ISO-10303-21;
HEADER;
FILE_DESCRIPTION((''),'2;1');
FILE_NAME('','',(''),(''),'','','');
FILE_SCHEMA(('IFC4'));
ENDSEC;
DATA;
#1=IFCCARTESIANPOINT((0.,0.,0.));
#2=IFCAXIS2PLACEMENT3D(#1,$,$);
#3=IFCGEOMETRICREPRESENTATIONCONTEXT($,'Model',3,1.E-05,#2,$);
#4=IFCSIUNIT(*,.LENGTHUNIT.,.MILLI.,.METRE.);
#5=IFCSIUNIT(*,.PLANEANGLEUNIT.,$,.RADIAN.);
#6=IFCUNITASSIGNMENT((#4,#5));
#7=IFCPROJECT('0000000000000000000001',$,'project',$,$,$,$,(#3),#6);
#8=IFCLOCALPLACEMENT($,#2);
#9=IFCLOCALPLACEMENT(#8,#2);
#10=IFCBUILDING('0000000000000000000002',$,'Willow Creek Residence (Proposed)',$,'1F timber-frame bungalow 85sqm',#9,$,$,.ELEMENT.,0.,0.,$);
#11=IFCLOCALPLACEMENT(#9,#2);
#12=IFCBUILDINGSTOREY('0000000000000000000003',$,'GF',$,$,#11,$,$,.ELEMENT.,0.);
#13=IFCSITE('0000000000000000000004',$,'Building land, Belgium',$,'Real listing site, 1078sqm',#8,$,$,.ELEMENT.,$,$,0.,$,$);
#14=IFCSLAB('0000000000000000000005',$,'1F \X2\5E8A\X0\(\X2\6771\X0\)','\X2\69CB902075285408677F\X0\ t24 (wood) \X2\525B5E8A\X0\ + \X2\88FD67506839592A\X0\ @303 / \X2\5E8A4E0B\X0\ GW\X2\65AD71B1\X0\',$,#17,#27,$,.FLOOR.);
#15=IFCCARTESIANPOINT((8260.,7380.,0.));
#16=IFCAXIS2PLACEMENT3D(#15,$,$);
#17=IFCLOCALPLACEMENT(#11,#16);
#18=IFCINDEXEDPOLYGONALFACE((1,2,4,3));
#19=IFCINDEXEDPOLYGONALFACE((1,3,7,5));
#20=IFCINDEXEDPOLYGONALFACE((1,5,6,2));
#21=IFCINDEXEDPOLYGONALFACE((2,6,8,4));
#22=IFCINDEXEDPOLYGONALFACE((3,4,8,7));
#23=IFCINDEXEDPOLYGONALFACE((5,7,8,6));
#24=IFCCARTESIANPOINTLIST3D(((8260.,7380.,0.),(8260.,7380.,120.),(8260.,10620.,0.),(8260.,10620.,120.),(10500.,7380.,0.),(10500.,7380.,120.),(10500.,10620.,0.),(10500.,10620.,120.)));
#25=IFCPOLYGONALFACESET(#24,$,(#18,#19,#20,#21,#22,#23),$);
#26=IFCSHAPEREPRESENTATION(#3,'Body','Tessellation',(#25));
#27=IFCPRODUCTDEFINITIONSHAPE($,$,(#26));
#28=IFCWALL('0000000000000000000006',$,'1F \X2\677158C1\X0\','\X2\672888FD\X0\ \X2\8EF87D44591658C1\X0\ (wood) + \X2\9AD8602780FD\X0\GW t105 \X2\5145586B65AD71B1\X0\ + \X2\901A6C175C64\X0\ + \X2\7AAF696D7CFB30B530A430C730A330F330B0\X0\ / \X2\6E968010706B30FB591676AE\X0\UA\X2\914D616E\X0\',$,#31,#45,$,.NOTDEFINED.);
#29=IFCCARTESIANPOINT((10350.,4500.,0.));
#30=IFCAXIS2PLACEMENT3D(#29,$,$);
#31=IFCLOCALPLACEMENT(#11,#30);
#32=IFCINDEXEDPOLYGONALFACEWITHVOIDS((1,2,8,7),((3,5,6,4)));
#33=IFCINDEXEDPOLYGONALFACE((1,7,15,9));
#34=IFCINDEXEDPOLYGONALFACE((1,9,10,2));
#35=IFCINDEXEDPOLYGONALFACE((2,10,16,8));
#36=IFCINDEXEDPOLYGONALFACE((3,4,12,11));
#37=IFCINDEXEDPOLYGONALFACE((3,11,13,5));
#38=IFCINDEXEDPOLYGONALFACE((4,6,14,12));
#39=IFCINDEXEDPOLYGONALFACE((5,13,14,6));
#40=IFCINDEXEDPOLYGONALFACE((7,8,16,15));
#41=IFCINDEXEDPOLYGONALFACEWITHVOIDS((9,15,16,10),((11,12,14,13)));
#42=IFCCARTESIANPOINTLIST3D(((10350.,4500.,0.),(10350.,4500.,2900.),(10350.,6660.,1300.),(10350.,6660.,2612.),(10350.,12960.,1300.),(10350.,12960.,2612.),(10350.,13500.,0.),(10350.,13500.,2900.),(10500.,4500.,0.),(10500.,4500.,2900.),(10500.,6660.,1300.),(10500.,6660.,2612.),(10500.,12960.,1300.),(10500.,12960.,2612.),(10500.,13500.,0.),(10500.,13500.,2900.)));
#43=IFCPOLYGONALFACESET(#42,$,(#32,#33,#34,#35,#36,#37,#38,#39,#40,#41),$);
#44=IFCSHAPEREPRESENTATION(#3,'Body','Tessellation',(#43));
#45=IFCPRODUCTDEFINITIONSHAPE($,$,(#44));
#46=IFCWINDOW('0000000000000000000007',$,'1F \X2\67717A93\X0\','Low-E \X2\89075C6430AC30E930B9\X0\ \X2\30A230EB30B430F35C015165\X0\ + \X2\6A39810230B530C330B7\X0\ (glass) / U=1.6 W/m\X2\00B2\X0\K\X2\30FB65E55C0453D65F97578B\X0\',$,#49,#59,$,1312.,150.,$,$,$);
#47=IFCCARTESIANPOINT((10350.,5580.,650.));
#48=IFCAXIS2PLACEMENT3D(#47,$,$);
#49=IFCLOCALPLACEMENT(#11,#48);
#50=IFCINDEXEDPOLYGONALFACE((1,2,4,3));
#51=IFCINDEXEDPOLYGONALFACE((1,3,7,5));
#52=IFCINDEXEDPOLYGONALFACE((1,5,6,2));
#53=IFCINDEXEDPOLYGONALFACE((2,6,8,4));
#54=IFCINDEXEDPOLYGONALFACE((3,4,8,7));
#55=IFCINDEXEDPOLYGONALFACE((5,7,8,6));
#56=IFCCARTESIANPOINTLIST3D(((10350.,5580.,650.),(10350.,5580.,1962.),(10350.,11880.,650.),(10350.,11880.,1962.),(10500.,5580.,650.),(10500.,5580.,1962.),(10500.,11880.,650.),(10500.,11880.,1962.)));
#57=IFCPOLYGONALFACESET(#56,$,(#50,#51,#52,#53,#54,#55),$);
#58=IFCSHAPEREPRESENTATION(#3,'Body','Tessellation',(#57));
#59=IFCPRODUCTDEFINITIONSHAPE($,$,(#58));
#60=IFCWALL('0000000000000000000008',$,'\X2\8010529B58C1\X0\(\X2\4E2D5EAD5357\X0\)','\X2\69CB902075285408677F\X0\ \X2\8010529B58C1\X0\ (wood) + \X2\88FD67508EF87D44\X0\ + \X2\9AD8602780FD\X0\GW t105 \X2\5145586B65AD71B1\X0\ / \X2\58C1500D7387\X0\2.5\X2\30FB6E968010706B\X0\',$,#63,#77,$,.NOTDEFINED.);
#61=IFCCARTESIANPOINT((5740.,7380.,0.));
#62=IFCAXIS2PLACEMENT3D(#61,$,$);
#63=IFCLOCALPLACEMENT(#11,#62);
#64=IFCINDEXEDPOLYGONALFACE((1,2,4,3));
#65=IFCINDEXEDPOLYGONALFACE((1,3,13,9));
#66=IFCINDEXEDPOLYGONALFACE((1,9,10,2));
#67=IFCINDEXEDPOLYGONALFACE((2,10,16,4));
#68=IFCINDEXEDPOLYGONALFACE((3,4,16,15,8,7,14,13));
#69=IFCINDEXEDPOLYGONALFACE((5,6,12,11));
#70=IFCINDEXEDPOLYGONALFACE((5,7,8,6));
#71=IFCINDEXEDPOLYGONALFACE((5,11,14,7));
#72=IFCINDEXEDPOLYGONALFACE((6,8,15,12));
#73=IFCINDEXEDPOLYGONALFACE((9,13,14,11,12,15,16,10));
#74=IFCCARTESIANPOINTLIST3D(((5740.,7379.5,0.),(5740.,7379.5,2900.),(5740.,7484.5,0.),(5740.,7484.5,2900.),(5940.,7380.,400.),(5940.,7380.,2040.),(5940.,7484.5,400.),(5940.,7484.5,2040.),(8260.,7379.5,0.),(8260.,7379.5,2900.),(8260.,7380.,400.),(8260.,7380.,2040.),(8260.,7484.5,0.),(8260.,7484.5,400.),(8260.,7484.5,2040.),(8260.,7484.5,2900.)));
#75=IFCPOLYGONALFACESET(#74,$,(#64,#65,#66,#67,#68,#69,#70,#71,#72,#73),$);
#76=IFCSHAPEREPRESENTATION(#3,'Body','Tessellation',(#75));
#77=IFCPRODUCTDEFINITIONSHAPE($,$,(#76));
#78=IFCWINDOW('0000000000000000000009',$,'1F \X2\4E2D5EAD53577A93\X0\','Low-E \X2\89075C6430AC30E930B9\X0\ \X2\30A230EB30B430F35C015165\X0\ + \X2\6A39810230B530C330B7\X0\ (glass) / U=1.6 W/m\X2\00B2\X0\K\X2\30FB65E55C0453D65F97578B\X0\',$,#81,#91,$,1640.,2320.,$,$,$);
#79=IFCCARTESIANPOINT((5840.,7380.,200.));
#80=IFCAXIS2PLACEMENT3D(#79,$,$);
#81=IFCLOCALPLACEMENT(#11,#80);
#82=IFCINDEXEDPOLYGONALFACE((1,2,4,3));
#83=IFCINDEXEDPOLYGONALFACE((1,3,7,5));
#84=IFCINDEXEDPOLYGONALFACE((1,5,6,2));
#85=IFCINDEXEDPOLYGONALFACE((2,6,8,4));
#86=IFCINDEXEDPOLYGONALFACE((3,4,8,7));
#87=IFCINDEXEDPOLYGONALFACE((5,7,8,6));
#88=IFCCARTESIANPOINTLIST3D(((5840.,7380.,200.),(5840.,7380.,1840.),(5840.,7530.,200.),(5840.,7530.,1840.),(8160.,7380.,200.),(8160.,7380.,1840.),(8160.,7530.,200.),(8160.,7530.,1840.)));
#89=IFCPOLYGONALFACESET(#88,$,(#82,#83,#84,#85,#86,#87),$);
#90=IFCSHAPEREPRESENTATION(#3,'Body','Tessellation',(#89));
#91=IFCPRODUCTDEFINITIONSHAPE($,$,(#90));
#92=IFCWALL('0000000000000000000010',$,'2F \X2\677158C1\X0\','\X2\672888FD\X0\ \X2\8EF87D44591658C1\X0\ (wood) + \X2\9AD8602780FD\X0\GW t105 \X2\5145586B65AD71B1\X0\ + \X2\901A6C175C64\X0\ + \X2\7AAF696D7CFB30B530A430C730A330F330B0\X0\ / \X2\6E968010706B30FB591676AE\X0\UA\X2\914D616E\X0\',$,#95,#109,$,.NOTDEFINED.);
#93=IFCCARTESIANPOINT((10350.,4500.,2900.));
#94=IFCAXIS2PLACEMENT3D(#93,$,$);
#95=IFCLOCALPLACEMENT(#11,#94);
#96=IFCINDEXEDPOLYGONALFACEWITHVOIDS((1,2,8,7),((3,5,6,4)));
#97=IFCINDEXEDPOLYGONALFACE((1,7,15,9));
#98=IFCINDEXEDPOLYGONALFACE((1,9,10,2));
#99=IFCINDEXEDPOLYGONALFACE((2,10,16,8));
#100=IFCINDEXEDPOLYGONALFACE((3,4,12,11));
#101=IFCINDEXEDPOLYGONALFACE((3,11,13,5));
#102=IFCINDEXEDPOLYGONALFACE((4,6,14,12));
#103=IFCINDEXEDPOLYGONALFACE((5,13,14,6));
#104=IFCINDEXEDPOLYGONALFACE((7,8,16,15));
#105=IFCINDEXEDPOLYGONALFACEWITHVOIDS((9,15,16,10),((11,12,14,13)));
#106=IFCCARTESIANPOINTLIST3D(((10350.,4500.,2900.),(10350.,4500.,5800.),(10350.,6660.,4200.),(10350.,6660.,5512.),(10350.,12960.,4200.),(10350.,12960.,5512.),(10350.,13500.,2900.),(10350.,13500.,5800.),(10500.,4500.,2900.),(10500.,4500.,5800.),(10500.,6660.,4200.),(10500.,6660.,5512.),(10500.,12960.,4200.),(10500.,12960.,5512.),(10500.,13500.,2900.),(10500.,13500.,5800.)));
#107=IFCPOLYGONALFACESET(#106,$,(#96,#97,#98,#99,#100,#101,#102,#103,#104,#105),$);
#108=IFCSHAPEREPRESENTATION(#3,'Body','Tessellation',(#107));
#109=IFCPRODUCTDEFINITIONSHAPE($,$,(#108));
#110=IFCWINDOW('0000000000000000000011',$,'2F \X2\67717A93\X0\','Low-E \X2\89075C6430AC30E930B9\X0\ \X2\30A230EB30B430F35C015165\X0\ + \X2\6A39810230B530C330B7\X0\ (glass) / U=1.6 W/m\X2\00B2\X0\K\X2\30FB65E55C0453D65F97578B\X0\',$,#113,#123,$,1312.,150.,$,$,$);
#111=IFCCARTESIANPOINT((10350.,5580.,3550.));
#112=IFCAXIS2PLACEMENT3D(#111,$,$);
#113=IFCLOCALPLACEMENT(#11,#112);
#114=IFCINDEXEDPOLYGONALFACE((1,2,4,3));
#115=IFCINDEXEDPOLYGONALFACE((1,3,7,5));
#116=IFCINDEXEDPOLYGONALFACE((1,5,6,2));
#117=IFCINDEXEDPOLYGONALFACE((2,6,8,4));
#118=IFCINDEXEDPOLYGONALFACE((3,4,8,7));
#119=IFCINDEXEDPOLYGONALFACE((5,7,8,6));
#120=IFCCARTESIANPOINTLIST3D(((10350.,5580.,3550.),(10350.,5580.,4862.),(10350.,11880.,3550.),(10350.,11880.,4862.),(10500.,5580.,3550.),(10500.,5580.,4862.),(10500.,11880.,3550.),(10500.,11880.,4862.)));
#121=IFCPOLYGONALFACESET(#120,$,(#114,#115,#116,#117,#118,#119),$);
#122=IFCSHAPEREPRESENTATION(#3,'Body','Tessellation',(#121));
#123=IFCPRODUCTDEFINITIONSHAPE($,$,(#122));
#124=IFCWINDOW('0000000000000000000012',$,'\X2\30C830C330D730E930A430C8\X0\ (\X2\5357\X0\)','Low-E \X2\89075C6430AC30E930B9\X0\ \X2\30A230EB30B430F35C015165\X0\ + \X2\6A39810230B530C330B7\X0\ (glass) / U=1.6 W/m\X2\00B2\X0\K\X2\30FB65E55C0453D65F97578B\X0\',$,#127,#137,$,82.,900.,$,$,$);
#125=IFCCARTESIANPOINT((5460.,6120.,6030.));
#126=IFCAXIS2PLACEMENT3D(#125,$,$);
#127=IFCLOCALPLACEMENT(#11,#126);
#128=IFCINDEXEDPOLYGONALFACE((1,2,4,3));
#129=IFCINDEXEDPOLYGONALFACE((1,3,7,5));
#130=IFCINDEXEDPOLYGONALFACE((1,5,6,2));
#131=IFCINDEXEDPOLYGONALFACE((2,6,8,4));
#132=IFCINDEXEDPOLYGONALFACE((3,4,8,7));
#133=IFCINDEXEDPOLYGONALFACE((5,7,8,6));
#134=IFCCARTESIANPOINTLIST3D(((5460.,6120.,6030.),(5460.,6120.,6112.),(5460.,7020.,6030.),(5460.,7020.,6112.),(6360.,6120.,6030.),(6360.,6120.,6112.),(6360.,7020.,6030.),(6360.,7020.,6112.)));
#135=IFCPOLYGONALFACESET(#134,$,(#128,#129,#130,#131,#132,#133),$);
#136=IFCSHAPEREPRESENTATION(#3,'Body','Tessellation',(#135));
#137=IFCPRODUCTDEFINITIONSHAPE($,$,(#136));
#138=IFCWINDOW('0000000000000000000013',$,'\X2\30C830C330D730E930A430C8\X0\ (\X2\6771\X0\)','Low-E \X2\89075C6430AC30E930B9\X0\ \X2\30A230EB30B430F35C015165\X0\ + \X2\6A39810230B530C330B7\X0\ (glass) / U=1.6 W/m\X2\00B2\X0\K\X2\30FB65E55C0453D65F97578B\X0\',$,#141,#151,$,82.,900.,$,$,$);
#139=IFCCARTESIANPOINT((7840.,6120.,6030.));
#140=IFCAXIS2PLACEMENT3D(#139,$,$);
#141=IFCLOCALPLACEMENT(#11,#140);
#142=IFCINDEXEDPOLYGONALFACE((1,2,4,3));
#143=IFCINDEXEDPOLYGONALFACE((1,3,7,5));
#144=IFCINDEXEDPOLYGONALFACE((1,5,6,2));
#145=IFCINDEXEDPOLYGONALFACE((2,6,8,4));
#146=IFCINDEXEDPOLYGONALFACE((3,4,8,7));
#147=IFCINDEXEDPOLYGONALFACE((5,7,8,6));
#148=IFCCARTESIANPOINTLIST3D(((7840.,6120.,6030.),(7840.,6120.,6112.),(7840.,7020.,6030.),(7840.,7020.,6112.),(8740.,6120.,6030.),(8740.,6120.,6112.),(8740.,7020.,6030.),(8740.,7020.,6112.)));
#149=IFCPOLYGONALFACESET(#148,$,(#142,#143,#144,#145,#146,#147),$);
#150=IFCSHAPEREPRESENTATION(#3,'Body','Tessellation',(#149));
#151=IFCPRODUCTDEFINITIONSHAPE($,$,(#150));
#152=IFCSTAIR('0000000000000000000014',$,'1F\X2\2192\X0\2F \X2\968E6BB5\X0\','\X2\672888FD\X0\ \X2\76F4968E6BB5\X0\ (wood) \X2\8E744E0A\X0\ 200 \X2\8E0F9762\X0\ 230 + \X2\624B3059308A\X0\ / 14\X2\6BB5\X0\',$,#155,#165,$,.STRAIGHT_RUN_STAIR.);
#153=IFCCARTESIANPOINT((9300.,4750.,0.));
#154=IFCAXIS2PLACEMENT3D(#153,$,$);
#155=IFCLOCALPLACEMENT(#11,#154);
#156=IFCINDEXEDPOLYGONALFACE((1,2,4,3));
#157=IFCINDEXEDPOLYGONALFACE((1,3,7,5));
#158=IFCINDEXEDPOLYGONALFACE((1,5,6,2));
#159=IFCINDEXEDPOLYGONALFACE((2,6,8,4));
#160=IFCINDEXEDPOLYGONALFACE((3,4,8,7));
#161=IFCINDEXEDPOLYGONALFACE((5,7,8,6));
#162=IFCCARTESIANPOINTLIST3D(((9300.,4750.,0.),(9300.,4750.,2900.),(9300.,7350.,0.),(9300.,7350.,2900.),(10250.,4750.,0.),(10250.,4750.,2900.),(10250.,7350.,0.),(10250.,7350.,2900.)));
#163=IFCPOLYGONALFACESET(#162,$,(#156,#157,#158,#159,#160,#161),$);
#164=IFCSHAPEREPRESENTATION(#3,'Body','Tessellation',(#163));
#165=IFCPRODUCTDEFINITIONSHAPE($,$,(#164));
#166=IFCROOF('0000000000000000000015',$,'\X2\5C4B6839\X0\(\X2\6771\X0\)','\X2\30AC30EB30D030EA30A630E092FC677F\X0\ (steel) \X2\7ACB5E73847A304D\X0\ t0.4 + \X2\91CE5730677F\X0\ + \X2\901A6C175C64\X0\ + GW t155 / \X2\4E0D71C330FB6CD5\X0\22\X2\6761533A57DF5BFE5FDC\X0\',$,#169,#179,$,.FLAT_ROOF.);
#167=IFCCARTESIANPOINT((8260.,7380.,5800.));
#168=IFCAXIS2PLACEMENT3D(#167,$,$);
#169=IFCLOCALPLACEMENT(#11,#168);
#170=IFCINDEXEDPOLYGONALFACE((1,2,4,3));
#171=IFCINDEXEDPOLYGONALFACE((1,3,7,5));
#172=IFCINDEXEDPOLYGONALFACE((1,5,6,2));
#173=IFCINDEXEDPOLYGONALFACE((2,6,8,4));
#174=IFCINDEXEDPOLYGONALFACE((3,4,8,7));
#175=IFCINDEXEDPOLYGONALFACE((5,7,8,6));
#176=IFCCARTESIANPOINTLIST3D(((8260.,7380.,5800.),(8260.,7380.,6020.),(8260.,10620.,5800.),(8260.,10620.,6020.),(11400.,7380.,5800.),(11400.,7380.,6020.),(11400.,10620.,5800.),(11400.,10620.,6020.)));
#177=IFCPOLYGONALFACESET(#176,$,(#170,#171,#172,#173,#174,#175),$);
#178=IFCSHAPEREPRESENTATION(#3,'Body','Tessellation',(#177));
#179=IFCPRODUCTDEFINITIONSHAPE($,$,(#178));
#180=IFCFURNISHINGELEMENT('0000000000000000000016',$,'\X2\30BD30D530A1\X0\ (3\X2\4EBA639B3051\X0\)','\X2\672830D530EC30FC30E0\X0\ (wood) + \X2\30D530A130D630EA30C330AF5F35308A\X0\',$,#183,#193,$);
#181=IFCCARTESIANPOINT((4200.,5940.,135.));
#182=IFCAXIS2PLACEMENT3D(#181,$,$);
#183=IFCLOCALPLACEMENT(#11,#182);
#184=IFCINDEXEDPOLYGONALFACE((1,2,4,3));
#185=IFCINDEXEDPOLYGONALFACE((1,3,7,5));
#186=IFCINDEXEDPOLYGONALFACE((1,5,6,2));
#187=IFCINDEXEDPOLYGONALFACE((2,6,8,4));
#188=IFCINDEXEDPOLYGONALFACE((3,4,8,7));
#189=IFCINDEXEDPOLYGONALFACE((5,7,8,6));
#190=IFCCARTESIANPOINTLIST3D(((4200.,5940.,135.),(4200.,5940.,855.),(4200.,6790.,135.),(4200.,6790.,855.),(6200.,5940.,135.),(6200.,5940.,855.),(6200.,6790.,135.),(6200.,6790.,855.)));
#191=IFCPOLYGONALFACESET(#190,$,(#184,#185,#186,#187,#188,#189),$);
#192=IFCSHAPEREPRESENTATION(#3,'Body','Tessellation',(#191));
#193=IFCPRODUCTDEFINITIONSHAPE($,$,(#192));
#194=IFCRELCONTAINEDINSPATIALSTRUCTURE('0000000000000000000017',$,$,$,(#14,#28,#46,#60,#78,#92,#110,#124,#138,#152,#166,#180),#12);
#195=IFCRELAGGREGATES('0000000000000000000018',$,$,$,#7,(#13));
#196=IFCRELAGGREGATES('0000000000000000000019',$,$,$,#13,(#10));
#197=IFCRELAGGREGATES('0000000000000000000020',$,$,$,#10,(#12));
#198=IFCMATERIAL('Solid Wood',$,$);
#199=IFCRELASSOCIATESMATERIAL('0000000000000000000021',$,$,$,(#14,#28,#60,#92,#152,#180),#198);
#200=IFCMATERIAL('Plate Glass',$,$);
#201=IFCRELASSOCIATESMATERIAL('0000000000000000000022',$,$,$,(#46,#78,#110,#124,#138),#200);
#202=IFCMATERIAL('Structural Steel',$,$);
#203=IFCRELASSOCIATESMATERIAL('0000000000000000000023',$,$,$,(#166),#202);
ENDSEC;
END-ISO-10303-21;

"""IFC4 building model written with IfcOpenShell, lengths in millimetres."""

from ifc_helpers import new_model, si_unit, frame, frame_2d, origin, place, context, project, spatial, rectangle, extrude, material, element, fill, save


model = new_model("IFC4")

# Units and contexts
model_context = context("Model", 3, precision=1e-05, world=origin())
ifc_project = project(units=[si_unit("LENGTHUNIT", "METRE", prefix="MILLI"), si_unit("PLANEANGLEUNIT", "RADIAN")], contexts=[model_context])

# Site, building, storey
site_placement = place(None, origin())
site = spatial("IfcSite", under=ifc_project, at=site_placement, Name="Building land, Belgium", ObjectType="Real listing site, 1078sqm", CompositionType="ELEMENT", RefElevation=0.0)
building_placement = place(site_placement, origin())
building = spatial("IfcBuilding", under=site, at=building_placement, Name="Willow Creek Residence (Proposed)", ObjectType="1F timber-frame bungalow 85sqm", CompositionType="ELEMENT", ElevationOfRefHeight=0.0, ElevationOfTerrain=0.0)
storey_placement = place(building_placement, origin())
storey = spatial("IfcBuildingStorey", under=building, at=storey_placement, Name="GF", CompositionType="ELEMENT", Elevation=0.0)

# Slab
ifc_material_1 = material(Name="Solid Wood")
slab_placement = place(storey_placement, frame((8260.0, 7380.0, 0.0)))
element("IfcSlab", 1, at=slab_placement, inside=storey, material=ifc_material_1, Name="1F 床(東)", Description="構造用合板 t24 (wood) 剛床 + 製材根太 @303 / 床下 GW断熱", PredefinedType="FLOOR", context=model_context, shape_type="SweptSolid", body=[
    extrude(rectangle(XDim=2240.0, YDim=3240.0, at=frame_2d((1120.0, 1620.0))), frame((8260.0, 7380.0, 0.0)), (0.0, 0.0, 1.0), 120.0),
])

# Walls, openings, windows
wall_1_placement = place(storey_placement, frame((10350.0, 4500.0, 0.0)))
wall_1 = element("IfcWall", 2, at=wall_1_placement, inside=storey, material=ifc_material_1, Name="1F 東壁", Description="木製 軸組外壁 (wood) + 高性能GW t105 充填断熱 + 通気層 + 窯業系サイディング / 準耐火・外皮UA配慮", PredefinedType="NOTDEFINED", context=model_context, shape_type="SweptSolid", body=[
    extrude(rectangle(XDim=150.0, YDim=9000.0, at=frame_2d((75.0, 4500.0))), frame((10350.0, 4500.0, 0.0)), (0.0, 0.0, 1.0), 2900.0),
])
opening_1_placement = place(storey_placement, frame((10350.0, 5580.0, 650.0)))
opening_1 = element("IfcOpeningElement", 3, at=opening_1_placement, cuts=wall_1, PredefinedType="NOTDEFINED", context=model_context, shape_type="SweptSolid", body=[
    extrude(rectangle(XDim=150.0, YDim=6300.0, at=frame_2d((75.0, 3150.0))), frame((10350.0, 5580.0, 650.0)), (0.0, 0.0, 1.0), 1312.0),
])
ifc_material_2 = material(Name="Plate Glass")
window_1_placement = place(storey_placement, frame((10350.0, 5580.0, 650.0)))
window_1 = element("IfcWindow", 4, at=window_1_placement, inside=storey, material=ifc_material_2, Name="1F 東窓", Description="Low-E 複層ガラス アルゴン封入 + 樹脂サッシ (glass) / U=1.6 W/m²K・日射取得型", OverallHeight=1312.0, OverallWidth=150.0, context=model_context, shape_type="SweptSolid", body=[
    extrude(rectangle(XDim=150.0, YDim=6300.0, at=frame_2d((75.0, 3150.0))), frame((10350.0, 5580.0, 650.0)), (0.0, 0.0, 1.0), 1312.0),
])
fill(opening_1, window_1)
wall_2_placement = place(storey_placement, frame((5740.0, 7380.0, 0.0)))
wall_2 = element("IfcWall", 5, at=wall_2_placement, inside=storey, material=ifc_material_1, Name="耐力壁(中庭南)", Description="構造用合板 耐力壁 (wood) + 製材軸組 + 高性能GW t105 充填断熱 / 壁倍率2.5・準耐火", PredefinedType="NOTDEFINED", context=model_context, shape_type="SweptSolid", body=[
    extrude(rectangle(XDim=2520.0, YDim=105.0, at=frame_2d((1260.0, 52.0))), frame((5740.0, 7380.0, 0.0)), (0.0, 0.0, 1.0), 2900.0),
])
opening_2_placement = place(storey_placement, frame((5840.0, 7380.0, 200.0)))
opening_2 = element("IfcOpeningElement", 6, at=opening_2_placement, cuts=wall_2, PredefinedType="NOTDEFINED", context=model_context, shape_type="SweptSolid", body=[
    extrude(rectangle(XDim=2320.0, YDim=150.0, at=frame_2d((1160.0, 75.0))), frame((5840.0, 7380.0, 200.0)), (0.0, 0.0, 1.0), 1640.0),
])
window_2_placement = place(storey_placement, frame((5840.0, 7380.0, 200.0)))
window_2 = element("IfcWindow", 7, at=window_2_placement, inside=storey, material=ifc_material_2, Name="1F 中庭南窓", Description="Low-E 複層ガラス アルゴン封入 + 樹脂サッシ (glass) / U=1.6 W/m²K・日射取得型", OverallHeight=1640.0, OverallWidth=2320.0, context=model_context, shape_type="SweptSolid", body=[
    extrude(rectangle(XDim=2320.0, YDim=150.0, at=frame_2d((1160.0, 75.0))), frame((5840.0, 7380.0, 200.0)), (0.0, 0.0, 1.0), 1640.0),
])
fill(opening_2, window_2)

# Wall, opening, window
wall_3_placement = place(storey_placement, frame((10350.0, 4500.0, 2900.0)))
wall_3 = element("IfcWall", 8, at=wall_3_placement, inside=storey, material=ifc_material_1, Name="2F 東壁", Description="木製 軸組外壁 (wood) + 高性能GW t105 充填断熱 + 通気層 + 窯業系サイディング / 準耐火・外皮UA配慮", PredefinedType="NOTDEFINED", context=model_context, shape_type="SweptSolid", body=[
    extrude(rectangle(XDim=150.0, YDim=9000.0, at=frame_2d((75.0, 4500.0))), frame((10350.0, 4500.0, 2900.0)), (0.0, 0.0, 1.0), 2900.0),
])
opening_3_placement = place(storey_placement, frame((10350.0, 5580.0, 3550.0)))
opening_3 = element("IfcOpeningElement", 9, at=opening_3_placement, cuts=wall_3, PredefinedType="NOTDEFINED", context=model_context, shape_type="SweptSolid", body=[
    extrude(rectangle(XDim=150.0, YDim=6300.0, at=frame_2d((75.0, 3150.0))), frame((10350.0, 5580.0, 3550.0)), (0.0, 0.0, 1.0), 1312.0),
])
window_3_placement = place(storey_placement, frame((10350.0, 5580.0, 3550.0)))
window_3 = element("IfcWindow", 10, at=window_3_placement, inside=storey, material=ifc_material_2, Name="2F 東窓", Description="Low-E 複層ガラス アルゴン封入 + 樹脂サッシ (glass) / U=1.6 W/m²K・日射取得型", OverallHeight=1312.0, OverallWidth=150.0, context=model_context, shape_type="SweptSolid", body=[
    extrude(rectangle(XDim=150.0, YDim=6300.0, at=frame_2d((75.0, 3150.0))), frame((10350.0, 5580.0, 3550.0)), (0.0, 0.0, 1.0), 1312.0),
])
fill(opening_3, window_3)

# Windows
window_4_placement = place(storey_placement, frame((5460.0, 6120.0, 6030.0)))
element("IfcWindow", 11, at=window_4_placement, inside=storey, material=ifc_material_2, Name="トップライト (南)", Description="Low-E 複層ガラス アルゴン封入 + 樹脂サッシ (glass) / U=1.6 W/m²K・日射取得型", OverallHeight=82.0, OverallWidth=900.0, context=model_context, shape_type="SweptSolid", body=[
    extrude(rectangle(XDim=900.0, YDim=900.0, at=frame_2d((450.0, 450.0))), frame((5460.0, 6120.0, 6030.0)), (0.0, 0.0, 1.0), 82.0),
])
window_5_placement = place(storey_placement, frame((7840.0, 6120.0, 6030.0)))
element("IfcWindow", 12, at=window_5_placement, inside=storey, material=ifc_material_2, Name="トップライト (東)", Description="Low-E 複層ガラス アルゴン封入 + 樹脂サッシ (glass) / U=1.6 W/m²K・日射取得型", OverallHeight=82.0, OverallWidth=900.0, context=model_context, shape_type="SweptSolid", body=[
    extrude(rectangle(XDim=900.0, YDim=900.0, at=frame_2d((450.0, 450.0))), frame((7840.0, 6120.0, 6030.0)), (0.0, 0.0, 1.0), 82.0),
])

# Stair
stair_placement = place(storey_placement, frame((9300.0, 4750.0, 0.0)))
element("IfcStair", 13, at=stair_placement, inside=storey, material=ifc_material_1, Name="1F→2F 階段", Description="木製 直階段 (wood) 蹴上 200 踏面 230 + 手すり / 14段", PredefinedType="STRAIGHT_RUN_STAIR", context=model_context, shape_type="SweptSolid", body=[
    extrude(rectangle(XDim=950.0, YDim=2600.0, at=frame_2d((475.0, 1300.0))), frame((9300.0, 4750.0, 0.0)), (0.0, 0.0, 1.0), 2900.0),
])

# Roof
ifc_material_3 = material(Name="Structural Steel")
roof_placement = place(storey_placement, frame((8260.0, 7380.0, 5800.0)))
element("IfcRoof", 14, at=roof_placement, inside=storey, material=ifc_material_3, Name="屋根(東)", Description="ガルバリウム鋼板 (steel) 立平葺き t0.4 + 野地板 + 通気層 + GW t155 / 不燃・法22条区域対応", PredefinedType="FLAT_ROOF", context=model_context, shape_type="SweptSolid", body=[
    extrude(rectangle(XDim=3140.0, YDim=3240.0, at=frame_2d((1570.0, 1620.0))), frame((8260.0, 7380.0, 5800.0)), (0.0, 0.0, 1.0), 220.0),
])

# Furnishing element
furnishing_1_placement = place(storey_placement, frame((4200.0, 5940.0, 135.0)))
element("IfcFurnishingElement", 15, at=furnishing_1_placement, inside=storey, material=ifc_material_1, Name="ソファ (3人掛け)", Description="木フレーム (wood) + ファブリック張り", context=model_context, shape_type="SweptSolid", body=[
    extrude(rectangle(XDim=2000.0, YDim=850.0, at=frame_2d((1000.0, 425.0))), frame((4200.0, 5940.0, 135.0)), (0.0, 0.0, 1.0), 720.0),
])

save(model, "model.ifc")
